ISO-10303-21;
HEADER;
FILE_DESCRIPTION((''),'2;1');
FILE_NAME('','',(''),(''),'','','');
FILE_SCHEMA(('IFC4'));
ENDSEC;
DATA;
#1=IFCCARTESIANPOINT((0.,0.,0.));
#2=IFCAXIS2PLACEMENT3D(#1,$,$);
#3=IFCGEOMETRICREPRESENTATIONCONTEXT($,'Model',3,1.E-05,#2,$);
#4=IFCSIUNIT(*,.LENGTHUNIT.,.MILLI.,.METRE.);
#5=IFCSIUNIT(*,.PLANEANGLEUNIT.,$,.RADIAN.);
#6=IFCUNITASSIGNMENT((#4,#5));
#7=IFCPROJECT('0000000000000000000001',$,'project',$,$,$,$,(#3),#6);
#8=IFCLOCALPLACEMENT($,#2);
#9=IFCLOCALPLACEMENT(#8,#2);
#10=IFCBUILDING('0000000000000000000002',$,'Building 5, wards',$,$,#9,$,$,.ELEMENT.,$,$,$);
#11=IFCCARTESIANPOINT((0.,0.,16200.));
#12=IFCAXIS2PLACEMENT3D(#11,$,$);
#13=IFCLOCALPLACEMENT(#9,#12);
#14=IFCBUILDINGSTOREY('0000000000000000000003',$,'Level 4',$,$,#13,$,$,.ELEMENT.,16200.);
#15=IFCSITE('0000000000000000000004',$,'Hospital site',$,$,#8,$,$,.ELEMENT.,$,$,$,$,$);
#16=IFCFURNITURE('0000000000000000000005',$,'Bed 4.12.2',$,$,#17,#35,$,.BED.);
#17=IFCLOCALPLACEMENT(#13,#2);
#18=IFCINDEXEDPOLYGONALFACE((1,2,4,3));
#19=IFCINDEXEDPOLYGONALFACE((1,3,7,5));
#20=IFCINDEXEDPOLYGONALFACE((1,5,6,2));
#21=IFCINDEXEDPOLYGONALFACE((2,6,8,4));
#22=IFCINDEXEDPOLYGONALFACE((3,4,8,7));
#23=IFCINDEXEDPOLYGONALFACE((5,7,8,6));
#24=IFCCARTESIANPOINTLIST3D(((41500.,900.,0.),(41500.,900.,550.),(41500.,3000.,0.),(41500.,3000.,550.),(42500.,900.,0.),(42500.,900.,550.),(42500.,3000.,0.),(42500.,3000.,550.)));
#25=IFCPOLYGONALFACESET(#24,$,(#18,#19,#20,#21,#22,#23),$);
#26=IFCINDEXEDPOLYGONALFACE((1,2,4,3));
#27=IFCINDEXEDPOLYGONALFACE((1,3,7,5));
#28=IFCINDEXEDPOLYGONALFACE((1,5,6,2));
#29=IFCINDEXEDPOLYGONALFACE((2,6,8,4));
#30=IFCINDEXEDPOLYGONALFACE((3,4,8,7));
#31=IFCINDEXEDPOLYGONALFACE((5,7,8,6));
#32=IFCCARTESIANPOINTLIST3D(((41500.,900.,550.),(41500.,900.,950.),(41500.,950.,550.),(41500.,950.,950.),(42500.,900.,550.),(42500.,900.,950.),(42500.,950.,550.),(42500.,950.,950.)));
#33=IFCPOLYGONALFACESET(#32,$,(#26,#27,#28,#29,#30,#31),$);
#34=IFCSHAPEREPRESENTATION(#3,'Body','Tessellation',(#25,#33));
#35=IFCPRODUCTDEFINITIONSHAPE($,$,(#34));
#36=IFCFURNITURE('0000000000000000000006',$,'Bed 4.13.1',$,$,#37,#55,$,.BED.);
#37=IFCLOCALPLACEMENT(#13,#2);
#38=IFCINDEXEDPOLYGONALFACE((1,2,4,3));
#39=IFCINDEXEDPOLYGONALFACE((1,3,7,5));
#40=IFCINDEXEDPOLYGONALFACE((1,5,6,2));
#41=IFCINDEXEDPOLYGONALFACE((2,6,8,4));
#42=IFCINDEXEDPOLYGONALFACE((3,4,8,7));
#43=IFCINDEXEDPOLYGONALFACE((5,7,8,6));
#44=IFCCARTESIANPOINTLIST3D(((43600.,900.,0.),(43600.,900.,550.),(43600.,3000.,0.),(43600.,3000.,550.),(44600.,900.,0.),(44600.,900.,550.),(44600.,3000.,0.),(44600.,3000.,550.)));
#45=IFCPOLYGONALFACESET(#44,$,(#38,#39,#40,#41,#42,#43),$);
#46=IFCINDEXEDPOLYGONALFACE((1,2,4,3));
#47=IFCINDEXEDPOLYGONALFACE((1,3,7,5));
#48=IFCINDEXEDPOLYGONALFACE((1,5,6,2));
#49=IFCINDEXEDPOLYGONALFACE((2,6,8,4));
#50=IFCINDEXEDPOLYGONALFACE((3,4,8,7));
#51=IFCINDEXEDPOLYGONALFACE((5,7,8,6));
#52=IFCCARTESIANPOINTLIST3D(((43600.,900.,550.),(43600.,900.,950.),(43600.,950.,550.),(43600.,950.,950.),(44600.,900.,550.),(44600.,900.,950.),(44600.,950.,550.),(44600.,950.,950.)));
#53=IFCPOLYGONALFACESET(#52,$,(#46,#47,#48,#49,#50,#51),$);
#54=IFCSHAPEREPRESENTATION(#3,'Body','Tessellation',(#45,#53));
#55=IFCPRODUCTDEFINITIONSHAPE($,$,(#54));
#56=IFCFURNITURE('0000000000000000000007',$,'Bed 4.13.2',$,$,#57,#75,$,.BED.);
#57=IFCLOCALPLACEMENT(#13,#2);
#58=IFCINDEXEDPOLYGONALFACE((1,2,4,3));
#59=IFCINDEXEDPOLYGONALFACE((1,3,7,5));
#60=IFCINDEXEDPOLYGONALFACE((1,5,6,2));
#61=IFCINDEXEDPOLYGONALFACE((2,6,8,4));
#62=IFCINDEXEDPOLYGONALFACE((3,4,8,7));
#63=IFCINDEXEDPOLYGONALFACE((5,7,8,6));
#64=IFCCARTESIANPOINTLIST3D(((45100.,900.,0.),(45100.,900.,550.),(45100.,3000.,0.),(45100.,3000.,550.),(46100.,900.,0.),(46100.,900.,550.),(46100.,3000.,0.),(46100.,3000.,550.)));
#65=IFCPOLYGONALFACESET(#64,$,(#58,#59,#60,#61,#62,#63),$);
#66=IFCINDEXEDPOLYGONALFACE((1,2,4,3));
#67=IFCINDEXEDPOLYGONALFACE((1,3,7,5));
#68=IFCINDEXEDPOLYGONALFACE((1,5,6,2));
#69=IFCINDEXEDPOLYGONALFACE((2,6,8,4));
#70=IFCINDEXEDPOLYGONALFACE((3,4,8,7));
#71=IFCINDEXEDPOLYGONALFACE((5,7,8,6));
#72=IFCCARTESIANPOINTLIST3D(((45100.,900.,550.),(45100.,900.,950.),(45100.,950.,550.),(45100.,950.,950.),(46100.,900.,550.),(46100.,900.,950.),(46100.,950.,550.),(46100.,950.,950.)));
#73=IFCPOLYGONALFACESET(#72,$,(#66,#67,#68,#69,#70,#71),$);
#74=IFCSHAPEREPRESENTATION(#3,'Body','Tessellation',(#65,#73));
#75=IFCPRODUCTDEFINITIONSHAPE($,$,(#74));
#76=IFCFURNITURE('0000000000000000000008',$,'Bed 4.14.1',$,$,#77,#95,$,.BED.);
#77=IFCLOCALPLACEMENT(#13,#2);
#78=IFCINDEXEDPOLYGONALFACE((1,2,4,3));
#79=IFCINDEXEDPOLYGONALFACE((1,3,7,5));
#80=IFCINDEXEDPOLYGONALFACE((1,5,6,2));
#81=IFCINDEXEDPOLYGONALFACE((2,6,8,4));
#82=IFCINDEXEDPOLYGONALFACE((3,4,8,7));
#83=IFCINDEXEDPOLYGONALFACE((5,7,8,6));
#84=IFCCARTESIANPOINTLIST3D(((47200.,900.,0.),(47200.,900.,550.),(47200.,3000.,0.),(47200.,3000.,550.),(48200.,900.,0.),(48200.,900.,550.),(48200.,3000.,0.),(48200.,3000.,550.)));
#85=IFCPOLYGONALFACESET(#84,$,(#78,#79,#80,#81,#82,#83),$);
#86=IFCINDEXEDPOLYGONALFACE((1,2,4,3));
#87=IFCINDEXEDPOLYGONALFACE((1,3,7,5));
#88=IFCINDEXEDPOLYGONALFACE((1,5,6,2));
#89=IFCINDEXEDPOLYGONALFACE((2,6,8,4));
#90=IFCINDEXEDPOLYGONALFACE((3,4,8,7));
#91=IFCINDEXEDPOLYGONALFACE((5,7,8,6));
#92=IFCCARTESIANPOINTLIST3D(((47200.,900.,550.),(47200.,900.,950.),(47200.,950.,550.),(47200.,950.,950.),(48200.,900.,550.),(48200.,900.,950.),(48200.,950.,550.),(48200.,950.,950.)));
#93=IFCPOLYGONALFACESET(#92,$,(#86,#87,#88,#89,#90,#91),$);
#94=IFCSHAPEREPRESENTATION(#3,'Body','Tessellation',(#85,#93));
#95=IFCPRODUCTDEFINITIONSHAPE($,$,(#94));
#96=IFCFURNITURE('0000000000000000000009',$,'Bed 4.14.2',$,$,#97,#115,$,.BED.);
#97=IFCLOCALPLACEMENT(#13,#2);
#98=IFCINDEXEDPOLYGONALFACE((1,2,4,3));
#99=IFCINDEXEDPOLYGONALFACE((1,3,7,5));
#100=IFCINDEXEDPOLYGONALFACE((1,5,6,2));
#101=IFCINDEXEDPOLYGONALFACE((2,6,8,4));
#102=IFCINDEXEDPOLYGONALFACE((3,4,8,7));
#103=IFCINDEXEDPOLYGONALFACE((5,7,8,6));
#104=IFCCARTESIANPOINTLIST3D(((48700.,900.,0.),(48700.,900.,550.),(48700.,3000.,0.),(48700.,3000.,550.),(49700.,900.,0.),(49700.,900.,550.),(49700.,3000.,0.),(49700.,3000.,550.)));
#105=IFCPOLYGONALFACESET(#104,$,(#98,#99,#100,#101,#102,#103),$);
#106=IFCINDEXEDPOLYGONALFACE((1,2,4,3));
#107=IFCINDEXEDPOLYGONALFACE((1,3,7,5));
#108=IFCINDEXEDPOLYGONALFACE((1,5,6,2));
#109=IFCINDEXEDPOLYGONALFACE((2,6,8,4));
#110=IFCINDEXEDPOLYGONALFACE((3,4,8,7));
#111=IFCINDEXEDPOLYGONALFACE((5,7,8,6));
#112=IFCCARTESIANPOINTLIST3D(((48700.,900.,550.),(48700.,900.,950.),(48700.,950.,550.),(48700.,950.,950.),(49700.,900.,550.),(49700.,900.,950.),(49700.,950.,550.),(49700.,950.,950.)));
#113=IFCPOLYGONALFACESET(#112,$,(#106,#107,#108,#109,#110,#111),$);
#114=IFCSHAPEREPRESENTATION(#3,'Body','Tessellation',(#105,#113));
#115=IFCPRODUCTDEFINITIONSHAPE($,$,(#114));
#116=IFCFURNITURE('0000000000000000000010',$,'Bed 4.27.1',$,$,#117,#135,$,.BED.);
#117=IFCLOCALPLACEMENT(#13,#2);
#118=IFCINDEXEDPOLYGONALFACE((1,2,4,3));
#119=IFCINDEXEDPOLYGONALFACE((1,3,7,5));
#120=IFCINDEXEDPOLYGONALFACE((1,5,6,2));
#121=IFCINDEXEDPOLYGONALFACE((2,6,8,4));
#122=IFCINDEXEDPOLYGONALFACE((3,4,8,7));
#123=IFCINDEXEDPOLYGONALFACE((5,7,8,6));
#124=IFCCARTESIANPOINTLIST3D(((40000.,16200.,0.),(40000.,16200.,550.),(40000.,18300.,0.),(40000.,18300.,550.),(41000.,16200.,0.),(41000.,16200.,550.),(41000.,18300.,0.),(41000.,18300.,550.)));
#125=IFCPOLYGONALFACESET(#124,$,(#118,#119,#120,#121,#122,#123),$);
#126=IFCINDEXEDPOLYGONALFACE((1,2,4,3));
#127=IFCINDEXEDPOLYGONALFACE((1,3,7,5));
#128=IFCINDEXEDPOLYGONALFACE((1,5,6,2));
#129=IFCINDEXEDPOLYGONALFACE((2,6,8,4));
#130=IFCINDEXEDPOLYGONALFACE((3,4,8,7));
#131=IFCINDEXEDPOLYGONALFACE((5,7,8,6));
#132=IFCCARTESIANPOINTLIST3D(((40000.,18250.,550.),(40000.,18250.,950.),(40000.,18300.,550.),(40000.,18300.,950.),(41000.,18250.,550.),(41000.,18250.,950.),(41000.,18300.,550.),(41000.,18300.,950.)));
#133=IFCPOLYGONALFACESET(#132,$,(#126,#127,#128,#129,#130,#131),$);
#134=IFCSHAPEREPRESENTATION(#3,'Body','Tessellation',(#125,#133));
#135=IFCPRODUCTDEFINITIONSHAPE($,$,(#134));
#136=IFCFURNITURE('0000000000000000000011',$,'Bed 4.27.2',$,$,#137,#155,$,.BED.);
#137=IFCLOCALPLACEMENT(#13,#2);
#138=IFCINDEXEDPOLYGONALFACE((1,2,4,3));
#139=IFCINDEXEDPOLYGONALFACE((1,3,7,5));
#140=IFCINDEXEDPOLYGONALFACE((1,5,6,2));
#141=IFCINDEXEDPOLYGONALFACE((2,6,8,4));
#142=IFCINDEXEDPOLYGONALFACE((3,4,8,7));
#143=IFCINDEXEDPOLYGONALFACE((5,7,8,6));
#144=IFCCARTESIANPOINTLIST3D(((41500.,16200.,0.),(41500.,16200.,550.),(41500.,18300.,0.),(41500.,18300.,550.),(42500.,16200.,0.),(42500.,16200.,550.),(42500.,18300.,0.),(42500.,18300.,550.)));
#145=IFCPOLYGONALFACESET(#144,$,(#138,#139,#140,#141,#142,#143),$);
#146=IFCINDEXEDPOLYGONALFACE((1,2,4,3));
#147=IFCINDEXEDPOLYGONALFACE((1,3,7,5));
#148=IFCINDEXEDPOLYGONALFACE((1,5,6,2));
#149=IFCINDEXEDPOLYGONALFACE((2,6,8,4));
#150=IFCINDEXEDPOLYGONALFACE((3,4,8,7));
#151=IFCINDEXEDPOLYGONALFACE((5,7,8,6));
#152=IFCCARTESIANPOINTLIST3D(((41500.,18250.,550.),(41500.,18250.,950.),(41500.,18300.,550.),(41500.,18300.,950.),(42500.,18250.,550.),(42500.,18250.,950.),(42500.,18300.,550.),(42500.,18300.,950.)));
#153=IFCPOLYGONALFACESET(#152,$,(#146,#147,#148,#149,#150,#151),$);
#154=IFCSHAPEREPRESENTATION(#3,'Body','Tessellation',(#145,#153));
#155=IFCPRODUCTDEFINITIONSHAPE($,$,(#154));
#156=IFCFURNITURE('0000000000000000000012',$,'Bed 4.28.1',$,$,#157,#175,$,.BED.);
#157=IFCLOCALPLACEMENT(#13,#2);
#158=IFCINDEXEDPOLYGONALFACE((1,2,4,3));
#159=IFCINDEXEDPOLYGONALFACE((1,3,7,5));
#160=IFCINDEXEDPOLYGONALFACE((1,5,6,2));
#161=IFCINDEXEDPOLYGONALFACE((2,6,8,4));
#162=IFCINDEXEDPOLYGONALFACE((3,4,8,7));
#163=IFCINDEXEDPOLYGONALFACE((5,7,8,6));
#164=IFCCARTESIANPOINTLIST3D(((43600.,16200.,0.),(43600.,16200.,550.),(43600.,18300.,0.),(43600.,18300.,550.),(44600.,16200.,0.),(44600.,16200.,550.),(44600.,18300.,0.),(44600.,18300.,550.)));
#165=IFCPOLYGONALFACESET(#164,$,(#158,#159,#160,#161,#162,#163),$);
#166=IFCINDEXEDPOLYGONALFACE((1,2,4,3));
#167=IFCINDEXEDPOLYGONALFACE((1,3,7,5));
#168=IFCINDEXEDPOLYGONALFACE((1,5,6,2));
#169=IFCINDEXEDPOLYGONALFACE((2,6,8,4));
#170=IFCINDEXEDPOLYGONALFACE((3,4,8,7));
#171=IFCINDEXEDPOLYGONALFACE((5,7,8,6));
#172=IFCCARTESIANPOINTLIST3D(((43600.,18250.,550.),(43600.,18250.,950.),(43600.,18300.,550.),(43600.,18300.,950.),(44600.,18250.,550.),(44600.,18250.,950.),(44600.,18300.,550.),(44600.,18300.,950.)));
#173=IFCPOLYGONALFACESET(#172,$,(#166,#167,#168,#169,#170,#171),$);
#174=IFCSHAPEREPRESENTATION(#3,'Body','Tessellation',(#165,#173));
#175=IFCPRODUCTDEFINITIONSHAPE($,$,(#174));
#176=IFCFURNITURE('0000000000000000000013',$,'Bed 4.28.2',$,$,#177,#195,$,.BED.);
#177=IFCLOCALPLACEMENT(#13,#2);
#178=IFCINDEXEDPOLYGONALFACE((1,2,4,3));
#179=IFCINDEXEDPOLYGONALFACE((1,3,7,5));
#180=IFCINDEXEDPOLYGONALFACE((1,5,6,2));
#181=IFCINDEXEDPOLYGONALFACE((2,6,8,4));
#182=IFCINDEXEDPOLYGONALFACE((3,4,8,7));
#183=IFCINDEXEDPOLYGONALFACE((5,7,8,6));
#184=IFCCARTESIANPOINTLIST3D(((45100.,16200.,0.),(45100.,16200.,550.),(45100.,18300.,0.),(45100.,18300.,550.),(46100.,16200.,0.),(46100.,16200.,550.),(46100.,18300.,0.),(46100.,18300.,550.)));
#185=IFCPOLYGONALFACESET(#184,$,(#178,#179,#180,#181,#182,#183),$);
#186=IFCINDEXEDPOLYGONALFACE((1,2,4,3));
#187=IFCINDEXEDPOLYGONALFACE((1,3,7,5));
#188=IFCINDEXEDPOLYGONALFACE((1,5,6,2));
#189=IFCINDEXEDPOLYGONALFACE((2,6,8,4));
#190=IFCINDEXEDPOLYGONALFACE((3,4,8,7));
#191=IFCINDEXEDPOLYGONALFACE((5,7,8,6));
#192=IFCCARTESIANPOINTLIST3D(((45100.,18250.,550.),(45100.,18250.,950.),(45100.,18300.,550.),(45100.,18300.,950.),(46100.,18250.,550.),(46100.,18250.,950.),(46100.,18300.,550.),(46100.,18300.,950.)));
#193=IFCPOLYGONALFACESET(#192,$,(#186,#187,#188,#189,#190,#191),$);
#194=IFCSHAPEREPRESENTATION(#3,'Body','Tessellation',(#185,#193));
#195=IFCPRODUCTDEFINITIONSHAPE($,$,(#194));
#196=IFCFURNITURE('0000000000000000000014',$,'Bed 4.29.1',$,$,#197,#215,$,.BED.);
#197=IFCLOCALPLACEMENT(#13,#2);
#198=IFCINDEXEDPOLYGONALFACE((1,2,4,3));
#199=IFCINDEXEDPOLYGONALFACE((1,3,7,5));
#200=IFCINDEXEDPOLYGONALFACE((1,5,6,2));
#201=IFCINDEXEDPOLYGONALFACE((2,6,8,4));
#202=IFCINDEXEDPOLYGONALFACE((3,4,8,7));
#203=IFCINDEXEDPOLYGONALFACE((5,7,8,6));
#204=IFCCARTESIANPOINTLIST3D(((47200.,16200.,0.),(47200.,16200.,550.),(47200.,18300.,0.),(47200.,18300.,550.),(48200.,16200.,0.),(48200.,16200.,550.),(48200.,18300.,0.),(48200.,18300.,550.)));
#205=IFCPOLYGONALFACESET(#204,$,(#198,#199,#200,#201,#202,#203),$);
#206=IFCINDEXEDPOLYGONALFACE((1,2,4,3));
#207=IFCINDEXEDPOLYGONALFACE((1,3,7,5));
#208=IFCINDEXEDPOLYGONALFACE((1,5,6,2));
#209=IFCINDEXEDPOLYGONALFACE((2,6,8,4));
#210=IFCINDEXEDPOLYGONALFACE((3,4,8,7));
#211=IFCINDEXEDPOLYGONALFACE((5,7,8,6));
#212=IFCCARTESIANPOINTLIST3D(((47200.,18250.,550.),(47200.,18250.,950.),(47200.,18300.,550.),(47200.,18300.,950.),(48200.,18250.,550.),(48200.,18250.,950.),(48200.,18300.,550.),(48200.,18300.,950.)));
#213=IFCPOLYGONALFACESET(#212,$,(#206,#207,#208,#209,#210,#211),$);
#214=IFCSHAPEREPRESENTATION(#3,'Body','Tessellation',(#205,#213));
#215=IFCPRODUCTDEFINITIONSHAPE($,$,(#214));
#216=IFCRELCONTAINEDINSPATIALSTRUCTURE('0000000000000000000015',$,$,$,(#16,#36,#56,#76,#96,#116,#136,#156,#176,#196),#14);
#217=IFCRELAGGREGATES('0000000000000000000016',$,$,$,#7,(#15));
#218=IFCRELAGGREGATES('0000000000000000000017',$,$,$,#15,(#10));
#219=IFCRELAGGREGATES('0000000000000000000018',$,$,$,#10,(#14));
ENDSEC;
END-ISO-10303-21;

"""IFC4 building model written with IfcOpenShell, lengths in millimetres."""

from ifc_helpers import new_model, si_unit, frame, frame_2d, origin, place, context, project, spatial, rectangle, extrude, element, save


model = new_model("IFC4")

# Units and contexts
model_context = context("Model", 3, precision=1e-05, world=origin())
ifc_project = project(units=[si_unit("LENGTHUNIT", "METRE", prefix="MILLI"), si_unit("PLANEANGLEUNIT", "RADIAN")], contexts=[model_context])

# Site, building, storey
site_placement = place(None, origin())
site = spatial("IfcSite", under=ifc_project, at=site_placement, Name="Hospital site", CompositionType="ELEMENT")
building_placement = place(site_placement, origin())
building = spatial("IfcBuilding", under=site, at=building_placement, Name="Building 5, wards", CompositionType="ELEMENT")
storey_placement = place(building_placement, frame((0.0, 0.0, 16200.0)))
storey = spatial("IfcBuildingStorey", under=building, at=storey_placement, Name="Level 4", CompositionType="ELEMENT", Elevation=16200.0)

# Furniture
for number, where, name in (
    (1, (41500.0, 900.0, 0.0), "Bed 4.12.2"),
    (2, (43600.0, 900.0, 0.0), "Bed 4.13.1"),
    (3, (45100.0, 900.0, 0.0), "Bed 4.13.2"),
    (4, (47200.0, 900.0, 0.0), "Bed 4.14.1"),
    (5, (48700.0, 900.0, 0.0), "Bed 4.14.2"),
):
    element("IfcFurniture", number, at=place(storey_placement, frame(where)), inside=storey, Name=name, PredefinedType="BED", context=model_context, shape_type="SweptSolid", body=[
        extrude(rectangle(XDim=1000.0, YDim=2100.0, at=frame_2d((500.0, 1050.0))), origin(), (0.0, 0.0, 1.0), 550.0),
        extrude(rectangle(XDim=1000.0, YDim=50.0, at=frame_2d((500.0, 25.0))), frame((0.0, 0.0, 550.0)), (0.0, 0.0, 1.0), 400.0),
    ])
for number, where, name in (
    (6, (40000.0, 16200.0, 0.0), "Bed 4.27.1"),
    (7, (41500.0, 16200.0, 0.0), "Bed 4.27.2"),
    (8, (43600.0, 16200.0, 0.0), "Bed 4.28.1"),
    (9, (45100.0, 16200.0, 0.0), "Bed 4.28.2"),
    (10, (47200.0, 16200.0, 0.0), "Bed 4.29.1"),
):
    element("IfcFurniture", number, at=place(storey_placement, frame(where)), inside=storey, Name=name, PredefinedType="BED", context=model_context, shape_type="SweptSolid", body=[
        extrude(rectangle(XDim=1000.0, YDim=2100.0, at=frame_2d((500.0, 1050.0))), origin(), (0.0, 0.0, 1.0), 550.0),
        extrude(rectangle(XDim=1000.0, YDim=50.0, at=frame_2d((500.0, 2075.0))), frame((0.0, 0.0, 550.0)), (0.0, 0.0, 1.0), 400.0),
    ])

save(model, "model.ifc")
